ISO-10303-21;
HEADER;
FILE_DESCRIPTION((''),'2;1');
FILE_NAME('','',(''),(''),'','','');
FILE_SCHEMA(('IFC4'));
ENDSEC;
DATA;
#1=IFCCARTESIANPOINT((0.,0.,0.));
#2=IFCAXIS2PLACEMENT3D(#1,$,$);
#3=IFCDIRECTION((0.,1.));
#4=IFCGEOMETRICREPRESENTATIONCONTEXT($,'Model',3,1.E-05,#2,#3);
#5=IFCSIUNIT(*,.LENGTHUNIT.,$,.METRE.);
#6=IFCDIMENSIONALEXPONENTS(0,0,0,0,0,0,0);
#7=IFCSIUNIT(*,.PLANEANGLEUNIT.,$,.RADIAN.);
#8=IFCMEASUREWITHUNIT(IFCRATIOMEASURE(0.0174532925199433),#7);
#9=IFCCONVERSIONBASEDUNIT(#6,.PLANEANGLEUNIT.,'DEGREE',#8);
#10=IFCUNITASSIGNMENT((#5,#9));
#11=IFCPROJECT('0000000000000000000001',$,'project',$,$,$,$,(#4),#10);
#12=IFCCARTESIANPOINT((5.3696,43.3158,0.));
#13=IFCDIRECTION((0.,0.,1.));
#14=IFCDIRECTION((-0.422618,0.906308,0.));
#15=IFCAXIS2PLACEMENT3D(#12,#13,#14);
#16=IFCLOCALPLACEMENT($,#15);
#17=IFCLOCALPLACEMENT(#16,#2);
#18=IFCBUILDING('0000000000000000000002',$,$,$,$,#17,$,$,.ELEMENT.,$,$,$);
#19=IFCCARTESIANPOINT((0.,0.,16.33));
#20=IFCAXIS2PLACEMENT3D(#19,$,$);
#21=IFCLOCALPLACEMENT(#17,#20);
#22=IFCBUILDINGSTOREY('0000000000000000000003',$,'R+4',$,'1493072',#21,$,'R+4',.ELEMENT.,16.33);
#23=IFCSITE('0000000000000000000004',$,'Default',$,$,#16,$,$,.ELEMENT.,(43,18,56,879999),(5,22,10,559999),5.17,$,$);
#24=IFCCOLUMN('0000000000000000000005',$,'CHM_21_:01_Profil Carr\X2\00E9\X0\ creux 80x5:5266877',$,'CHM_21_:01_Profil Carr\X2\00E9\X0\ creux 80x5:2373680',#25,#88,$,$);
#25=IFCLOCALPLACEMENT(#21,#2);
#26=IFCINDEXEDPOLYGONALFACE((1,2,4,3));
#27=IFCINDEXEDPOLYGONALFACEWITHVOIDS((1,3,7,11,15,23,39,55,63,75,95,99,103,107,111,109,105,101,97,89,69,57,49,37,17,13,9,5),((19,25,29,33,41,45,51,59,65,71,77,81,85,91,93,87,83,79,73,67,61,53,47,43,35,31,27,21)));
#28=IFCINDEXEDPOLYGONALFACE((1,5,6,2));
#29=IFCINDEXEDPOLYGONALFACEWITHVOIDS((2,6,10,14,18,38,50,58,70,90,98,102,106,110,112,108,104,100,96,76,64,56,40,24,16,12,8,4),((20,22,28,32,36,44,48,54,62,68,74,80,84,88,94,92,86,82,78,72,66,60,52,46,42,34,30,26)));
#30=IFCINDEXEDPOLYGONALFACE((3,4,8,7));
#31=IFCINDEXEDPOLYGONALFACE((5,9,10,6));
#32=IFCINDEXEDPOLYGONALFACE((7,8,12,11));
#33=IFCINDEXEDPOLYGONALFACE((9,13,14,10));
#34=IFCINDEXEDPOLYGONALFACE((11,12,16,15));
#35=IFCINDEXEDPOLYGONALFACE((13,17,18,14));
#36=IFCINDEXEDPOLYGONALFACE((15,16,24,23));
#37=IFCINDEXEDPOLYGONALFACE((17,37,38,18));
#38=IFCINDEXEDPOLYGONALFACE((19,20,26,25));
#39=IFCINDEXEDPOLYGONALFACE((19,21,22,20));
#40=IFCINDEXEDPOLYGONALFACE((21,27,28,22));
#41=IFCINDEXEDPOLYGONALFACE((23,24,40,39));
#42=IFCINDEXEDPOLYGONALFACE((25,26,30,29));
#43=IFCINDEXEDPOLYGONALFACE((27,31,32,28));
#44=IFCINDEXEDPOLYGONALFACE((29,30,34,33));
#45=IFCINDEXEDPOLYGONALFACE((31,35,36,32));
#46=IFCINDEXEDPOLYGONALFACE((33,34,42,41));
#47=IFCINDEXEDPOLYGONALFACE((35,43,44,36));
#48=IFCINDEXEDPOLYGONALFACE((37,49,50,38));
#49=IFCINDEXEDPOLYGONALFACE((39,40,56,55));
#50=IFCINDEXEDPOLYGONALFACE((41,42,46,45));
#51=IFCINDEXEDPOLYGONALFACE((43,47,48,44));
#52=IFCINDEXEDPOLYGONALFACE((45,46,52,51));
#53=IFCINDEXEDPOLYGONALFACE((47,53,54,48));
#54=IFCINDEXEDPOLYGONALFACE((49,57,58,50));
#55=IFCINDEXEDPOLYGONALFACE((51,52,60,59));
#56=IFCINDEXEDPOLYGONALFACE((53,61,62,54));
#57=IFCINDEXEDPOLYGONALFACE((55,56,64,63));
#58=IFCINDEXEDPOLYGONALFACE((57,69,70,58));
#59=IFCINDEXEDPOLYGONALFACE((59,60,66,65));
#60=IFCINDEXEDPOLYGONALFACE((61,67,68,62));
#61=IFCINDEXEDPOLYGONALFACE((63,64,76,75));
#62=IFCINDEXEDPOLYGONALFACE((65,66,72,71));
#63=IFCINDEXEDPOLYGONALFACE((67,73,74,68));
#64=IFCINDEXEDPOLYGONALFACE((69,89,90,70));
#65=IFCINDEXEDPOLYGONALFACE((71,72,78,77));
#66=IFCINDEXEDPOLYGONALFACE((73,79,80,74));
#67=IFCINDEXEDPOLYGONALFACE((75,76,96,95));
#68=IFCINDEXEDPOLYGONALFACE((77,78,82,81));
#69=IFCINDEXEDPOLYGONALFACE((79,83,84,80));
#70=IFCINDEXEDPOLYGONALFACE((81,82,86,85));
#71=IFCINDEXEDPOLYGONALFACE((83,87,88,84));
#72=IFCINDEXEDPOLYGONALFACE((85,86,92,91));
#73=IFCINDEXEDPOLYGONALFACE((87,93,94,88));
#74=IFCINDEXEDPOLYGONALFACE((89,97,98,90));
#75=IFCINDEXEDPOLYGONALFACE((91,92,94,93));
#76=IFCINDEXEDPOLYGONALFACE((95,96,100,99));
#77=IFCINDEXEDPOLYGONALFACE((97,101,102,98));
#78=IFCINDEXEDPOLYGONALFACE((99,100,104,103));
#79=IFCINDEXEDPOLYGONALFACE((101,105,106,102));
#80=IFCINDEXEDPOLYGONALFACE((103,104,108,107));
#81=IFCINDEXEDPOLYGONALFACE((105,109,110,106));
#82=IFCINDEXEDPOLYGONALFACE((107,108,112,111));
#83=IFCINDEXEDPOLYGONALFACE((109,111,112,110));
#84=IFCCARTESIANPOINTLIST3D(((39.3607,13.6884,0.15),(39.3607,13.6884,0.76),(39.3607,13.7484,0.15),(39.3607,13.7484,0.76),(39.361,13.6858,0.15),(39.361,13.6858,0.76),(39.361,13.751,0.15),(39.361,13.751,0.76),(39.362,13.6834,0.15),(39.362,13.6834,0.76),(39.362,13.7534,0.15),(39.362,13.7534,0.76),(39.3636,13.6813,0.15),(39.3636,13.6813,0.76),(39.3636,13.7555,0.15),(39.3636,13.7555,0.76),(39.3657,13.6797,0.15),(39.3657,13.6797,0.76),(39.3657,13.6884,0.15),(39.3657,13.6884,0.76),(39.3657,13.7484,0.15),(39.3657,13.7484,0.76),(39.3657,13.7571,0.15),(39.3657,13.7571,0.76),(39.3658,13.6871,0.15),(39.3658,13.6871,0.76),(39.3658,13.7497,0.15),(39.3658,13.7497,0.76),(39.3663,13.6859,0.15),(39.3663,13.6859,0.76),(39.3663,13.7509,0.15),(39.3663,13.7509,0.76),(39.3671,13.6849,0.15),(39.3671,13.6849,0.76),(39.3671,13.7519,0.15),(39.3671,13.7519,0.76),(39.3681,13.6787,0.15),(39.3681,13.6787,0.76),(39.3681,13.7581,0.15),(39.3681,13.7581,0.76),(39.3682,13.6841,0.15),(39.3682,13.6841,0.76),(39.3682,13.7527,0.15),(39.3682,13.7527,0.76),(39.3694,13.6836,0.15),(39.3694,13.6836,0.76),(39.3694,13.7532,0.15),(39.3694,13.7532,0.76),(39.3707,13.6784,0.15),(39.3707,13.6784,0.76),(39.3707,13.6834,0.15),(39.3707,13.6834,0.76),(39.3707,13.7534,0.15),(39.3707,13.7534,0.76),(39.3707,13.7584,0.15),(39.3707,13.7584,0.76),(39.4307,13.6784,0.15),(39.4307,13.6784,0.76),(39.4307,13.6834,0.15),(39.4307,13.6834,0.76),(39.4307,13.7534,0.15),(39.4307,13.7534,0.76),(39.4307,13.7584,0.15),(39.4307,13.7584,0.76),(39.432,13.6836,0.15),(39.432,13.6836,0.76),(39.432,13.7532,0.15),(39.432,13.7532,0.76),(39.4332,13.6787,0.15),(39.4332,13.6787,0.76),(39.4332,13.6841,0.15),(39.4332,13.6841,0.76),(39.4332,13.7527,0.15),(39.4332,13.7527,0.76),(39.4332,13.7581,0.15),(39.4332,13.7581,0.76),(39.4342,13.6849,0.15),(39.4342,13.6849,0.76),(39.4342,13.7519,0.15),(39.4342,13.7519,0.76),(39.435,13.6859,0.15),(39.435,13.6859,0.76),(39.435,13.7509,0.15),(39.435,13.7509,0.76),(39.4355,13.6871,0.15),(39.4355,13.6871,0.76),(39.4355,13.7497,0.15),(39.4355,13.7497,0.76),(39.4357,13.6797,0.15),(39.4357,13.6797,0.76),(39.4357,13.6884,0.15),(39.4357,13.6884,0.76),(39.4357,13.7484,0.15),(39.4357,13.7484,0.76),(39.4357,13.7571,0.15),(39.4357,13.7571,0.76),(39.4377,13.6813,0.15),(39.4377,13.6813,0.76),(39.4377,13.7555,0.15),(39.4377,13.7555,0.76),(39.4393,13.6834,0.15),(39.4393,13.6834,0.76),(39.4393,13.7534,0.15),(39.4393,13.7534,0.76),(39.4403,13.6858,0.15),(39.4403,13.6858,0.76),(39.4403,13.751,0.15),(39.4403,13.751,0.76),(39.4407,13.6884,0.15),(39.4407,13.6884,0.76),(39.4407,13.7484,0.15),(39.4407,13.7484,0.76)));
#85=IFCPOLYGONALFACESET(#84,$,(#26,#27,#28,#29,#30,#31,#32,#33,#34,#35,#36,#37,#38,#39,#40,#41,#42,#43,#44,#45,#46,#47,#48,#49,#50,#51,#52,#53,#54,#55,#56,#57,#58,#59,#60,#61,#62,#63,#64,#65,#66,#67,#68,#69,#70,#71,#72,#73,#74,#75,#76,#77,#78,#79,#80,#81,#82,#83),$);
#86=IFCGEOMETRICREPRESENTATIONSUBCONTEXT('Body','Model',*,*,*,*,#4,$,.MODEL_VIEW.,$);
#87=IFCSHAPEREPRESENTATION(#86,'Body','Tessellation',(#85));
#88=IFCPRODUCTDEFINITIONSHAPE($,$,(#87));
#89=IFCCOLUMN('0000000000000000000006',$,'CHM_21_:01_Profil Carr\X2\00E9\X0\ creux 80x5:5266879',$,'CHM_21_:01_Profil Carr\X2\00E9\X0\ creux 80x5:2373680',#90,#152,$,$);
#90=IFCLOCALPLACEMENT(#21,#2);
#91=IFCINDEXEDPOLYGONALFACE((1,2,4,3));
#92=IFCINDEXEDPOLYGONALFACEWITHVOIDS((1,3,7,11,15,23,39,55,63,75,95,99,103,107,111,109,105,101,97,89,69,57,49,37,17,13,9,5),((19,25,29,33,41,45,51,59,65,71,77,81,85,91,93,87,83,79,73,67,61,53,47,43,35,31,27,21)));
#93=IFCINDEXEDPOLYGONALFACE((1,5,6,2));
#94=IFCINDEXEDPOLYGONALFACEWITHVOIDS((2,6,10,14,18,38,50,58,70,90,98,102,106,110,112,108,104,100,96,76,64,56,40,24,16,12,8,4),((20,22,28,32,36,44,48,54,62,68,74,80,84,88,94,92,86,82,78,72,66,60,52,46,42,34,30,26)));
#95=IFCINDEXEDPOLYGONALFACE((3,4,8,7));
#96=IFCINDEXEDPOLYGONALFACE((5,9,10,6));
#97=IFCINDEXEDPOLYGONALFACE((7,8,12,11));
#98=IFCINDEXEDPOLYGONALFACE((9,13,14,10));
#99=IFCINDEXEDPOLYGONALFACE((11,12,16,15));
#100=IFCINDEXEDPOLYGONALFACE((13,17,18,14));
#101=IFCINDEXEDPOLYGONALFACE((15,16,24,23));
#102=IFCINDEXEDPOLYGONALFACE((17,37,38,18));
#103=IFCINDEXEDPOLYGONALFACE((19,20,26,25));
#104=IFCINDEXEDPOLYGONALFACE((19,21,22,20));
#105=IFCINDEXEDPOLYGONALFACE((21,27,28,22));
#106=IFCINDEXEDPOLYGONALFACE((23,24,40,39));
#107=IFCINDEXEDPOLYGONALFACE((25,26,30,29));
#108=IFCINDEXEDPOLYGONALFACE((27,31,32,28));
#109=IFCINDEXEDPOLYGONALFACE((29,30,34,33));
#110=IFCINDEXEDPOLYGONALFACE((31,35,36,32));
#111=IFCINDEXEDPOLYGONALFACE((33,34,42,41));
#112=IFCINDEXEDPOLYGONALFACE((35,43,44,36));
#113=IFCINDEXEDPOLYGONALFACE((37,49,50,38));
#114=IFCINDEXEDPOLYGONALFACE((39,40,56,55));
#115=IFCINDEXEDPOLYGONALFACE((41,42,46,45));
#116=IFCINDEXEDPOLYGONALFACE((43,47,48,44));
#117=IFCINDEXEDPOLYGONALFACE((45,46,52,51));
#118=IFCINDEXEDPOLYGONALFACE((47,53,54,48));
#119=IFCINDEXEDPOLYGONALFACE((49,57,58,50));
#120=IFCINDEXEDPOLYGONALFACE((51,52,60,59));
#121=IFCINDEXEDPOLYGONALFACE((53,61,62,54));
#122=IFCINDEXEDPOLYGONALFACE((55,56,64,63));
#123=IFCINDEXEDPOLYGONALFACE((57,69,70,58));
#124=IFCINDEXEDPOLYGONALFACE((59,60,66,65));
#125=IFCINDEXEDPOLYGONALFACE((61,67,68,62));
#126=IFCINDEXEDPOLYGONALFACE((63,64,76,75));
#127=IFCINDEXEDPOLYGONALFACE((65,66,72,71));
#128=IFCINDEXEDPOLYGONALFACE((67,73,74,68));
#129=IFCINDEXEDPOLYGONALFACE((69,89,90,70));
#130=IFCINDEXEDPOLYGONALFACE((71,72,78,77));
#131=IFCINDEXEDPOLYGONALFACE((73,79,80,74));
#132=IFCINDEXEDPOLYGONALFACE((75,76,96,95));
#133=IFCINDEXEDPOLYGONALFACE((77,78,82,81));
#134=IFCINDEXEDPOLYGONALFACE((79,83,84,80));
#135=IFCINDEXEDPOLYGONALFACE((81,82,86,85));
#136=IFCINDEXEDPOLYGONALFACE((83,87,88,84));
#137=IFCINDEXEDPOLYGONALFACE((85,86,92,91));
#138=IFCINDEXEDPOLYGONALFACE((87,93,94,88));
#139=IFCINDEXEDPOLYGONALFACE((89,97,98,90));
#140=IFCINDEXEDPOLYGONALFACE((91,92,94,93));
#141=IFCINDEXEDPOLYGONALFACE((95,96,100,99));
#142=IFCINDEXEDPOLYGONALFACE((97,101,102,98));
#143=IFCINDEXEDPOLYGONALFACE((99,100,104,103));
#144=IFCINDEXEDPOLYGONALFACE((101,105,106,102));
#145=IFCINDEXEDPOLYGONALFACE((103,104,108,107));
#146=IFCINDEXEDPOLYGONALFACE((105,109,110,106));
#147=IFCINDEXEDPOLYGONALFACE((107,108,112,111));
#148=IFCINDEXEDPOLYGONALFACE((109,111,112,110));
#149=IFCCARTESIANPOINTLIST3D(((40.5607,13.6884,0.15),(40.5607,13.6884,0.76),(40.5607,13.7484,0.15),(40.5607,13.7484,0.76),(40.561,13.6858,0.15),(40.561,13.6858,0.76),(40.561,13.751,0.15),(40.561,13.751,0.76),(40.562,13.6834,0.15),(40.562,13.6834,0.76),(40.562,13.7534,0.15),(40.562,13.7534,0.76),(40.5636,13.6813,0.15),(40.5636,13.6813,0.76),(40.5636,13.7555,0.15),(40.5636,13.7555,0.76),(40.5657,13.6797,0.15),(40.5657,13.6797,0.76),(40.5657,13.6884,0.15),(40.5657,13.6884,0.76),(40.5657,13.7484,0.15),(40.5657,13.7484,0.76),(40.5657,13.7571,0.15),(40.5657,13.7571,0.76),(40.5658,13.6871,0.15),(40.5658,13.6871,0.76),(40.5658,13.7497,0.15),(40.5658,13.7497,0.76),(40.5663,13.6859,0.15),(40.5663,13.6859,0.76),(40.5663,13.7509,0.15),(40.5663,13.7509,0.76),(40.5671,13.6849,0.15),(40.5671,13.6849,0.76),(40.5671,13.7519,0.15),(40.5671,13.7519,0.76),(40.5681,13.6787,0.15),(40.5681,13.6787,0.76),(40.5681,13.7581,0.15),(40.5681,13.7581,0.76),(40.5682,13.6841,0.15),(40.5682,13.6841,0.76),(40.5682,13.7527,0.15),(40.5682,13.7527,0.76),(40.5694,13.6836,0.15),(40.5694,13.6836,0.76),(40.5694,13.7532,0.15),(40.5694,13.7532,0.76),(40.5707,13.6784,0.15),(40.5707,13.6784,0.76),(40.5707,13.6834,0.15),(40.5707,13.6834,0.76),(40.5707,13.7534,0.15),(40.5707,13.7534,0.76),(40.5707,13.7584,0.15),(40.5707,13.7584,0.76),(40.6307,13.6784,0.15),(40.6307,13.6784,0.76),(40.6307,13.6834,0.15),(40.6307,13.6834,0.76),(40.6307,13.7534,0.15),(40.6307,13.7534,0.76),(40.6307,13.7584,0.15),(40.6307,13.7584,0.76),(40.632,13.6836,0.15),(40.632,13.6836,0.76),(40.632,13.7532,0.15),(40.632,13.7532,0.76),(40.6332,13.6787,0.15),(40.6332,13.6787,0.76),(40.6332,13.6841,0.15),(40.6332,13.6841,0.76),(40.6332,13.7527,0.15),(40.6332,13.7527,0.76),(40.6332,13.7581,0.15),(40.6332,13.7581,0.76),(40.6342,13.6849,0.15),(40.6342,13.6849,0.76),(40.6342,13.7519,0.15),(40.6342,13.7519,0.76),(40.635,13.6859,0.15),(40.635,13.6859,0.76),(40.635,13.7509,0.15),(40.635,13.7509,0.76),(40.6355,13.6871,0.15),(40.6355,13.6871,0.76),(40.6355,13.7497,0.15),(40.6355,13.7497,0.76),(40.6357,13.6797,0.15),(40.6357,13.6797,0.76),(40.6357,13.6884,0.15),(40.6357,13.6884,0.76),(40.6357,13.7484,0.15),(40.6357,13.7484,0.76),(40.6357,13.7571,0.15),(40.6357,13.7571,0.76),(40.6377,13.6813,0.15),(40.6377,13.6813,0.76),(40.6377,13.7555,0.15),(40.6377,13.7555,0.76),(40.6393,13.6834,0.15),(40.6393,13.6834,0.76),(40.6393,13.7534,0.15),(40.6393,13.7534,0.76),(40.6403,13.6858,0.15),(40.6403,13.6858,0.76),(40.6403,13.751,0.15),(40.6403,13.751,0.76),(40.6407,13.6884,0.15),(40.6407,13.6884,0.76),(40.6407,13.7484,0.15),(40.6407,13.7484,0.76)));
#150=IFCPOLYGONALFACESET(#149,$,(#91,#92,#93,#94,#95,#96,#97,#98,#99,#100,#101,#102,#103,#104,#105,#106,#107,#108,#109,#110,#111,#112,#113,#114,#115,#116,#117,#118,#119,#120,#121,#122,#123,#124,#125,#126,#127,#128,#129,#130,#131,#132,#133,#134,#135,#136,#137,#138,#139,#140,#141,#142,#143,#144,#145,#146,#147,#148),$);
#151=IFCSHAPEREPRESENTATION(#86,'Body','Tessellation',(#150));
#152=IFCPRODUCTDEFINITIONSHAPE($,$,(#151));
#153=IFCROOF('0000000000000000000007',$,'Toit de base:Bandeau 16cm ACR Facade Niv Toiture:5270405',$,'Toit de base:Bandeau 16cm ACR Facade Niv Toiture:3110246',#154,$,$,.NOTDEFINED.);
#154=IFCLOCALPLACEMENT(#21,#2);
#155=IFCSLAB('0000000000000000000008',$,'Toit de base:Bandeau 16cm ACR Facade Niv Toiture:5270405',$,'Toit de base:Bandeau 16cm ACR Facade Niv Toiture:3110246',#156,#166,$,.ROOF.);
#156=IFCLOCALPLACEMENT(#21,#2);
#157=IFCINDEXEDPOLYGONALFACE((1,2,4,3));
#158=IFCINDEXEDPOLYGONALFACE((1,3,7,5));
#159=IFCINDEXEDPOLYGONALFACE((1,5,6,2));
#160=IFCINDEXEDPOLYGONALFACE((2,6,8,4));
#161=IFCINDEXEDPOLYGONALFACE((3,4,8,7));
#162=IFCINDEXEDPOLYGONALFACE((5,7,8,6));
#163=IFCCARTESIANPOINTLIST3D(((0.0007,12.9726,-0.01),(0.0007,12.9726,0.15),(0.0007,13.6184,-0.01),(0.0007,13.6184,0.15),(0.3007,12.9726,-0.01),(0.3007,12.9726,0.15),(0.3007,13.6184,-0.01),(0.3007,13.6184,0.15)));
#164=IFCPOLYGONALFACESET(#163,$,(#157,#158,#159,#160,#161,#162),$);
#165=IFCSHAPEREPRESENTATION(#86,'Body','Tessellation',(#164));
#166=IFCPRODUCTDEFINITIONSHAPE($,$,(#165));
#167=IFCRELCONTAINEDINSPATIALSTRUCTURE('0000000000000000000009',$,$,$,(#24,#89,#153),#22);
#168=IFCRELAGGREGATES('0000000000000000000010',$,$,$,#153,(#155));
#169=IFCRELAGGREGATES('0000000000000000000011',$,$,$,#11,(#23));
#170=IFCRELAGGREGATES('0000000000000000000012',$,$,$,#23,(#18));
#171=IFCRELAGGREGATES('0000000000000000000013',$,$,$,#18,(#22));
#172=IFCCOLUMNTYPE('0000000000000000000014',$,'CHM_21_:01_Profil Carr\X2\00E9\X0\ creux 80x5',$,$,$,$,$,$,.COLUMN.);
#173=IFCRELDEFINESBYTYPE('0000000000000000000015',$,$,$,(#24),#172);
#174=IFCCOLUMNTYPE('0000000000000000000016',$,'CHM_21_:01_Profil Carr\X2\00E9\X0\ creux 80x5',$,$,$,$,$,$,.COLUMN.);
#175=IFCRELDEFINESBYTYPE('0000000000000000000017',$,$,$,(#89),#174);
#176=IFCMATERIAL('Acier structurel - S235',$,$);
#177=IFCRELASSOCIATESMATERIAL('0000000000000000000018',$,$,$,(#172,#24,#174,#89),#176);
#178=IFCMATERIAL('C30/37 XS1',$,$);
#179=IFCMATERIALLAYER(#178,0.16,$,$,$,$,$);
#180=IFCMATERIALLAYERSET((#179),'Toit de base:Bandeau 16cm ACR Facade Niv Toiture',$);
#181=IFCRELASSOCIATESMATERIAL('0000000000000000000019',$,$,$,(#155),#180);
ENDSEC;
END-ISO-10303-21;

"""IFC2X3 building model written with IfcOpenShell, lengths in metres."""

from ifc_helpers import new_model, entity, si_unit, converted_unit, direction, frame, frame_2d, origin, place, context, subcontext, project, spatial, polyline, circle_curve, parameter, trimmed, segment, composite_curve, rectangle, outline, extrude, source, transform, mapped, material, layer, layer_set, type_object, type_shapes, element, aggregate, save


model = new_model("IFC2X3")

# Units and contexts
model_context = context("Model", 3, precision=1e-05, world=origin(), true_north=direction((0.0, 1.0)))
body_context = subcontext(model_context, "Body", "Model", "MODEL_VIEW")
ifc_project = project(units=[si_unit("LENGTHUNIT", "METRE"), converted_unit("PLANEANGLEUNIT", "DEGREE", entity("IfcRatioMeasure", 0.0174532925199433), si_unit("PLANEANGLEUNIT", "RADIAN"), dimensions=[0, 0, 0, 0, 0, 0, 0])], contexts=[model_context])

# Site, building, storey
site_placement = place(None, frame((5.3696, 43.3158, 0.0), z_axis=(0.0, 0.0, 1.0), x_axis=(-0.422618, 0.906308, 0.0)))
site = spatial("IfcSite", under=ifc_project, at=site_placement, Name="Default", CompositionType="ELEMENT", RefLatitude=(43, 18, 56, 879999), RefLongitude=(5, 22, 10, 559999), RefElevation=5.17)
building_placement = place(site_placement, origin())
building = spatial("IfcBuilding", under=site, at=building_placement, CompositionType="ELEMENT")
storey_placement = place(building_placement, frame((0.0, 0.0, 16.33)))
storey = spatial("IfcBuildingStorey", under=building, at=storey_placement, Name="R+4", ObjectType="1493072", LongName="R+4", CompositionType="ELEMENT", Elevation=16.33)

# Columns
ifc_material_1 = material(Name="Acier structurel - S235")
column_type_1 = type_object("IfcColumnType", Name="CHM_21_:01_Profil Carré creux 80x5", PredefinedType="COLUMN", material=ifc_material_1)
shared_shape_1 = source(origin(), body_context, "Body", "SweptSolid", [
    extrude(outline(composite_curve([segment(polyline([(-0.03, -0.04), (0.03, -0.04)]), True, "CONTINUOUS"), segment(trimmed(circle_curve(frame_2d((0.03, -0.03), x_axis=(-1.0, 0.0)), 0.01), [parameter(90.0)], [parameter(180.0)], True, "PARAMETER"), True, "CONTINUOUS"), segment(polyline([(0.04, -0.03), (0.04, 0.03)]), True, "CONTINUOUS"), segment(trimmed(circle_curve(frame_2d((0.03, 0.03), x_axis=(-1.0, 0.0)), 0.01), [parameter(180.0)], [parameter(270.0)], True, "PARAMETER"), True, "CONTINUOUS"), segment(polyline([(0.03, 0.04), (-0.03, 0.04)]), True, "CONTINUOUS"), segment(trimmed(circle_curve(frame_2d((-0.03, 0.03), x_axis=(-1.0, 0.0)), 0.01), [parameter(270.0)], [parameter(360.0)], True, "PARAMETER"), True, "CONTINUOUS"), segment(polyline([(-0.04, 0.03), (-0.04, -0.03)]), True, "CONTINUOUS"), segment(trimmed(circle_curve(frame_2d((-0.03, -0.03), x_axis=(-1.0, 0.0)), 0.01), [parameter(360.0)], [parameter(90.0)], True, "PARAMETER"), True, "CONTINUOUS")], self_intersect=False), holes=[composite_curve([segment(trimmed(circle_curve(frame_2d((-0.03, -0.03), x_axis=(-1.0, 0.0)), 0.005), [parameter(360.0)], [parameter(90.0)], True, "PARAMETER"), False, "CONTINUOUS"), segment(polyline([(-0.035, -0.03), (-0.035, 0.03)]), True, "CONTINUOUS"), segment(trimmed(circle_curve(frame_2d((-0.03, 0.03), x_axis=(-1.0, 0.0)), 0.005), [parameter(270.0)], [parameter(360.0)], True, "PARAMETER"), False, "CONTINUOUS"), segment(polyline([(-0.03, 0.035), (0.03, 0.035)]), True, "CONTINUOUS"), segment(trimmed(circle_curve(frame_2d((0.03, 0.03), x_axis=(-1.0, 0.0)), 0.005), [parameter(180.0)], [parameter(270.0)], True, "PARAMETER"), False, "CONTINUOUS"), segment(polyline([(0.035, 0.03), (0.035, -0.03)]), True, "CONTINUOUS"), segment(trimmed(circle_curve(frame_2d((0.03, -0.03), x_axis=(-1.0, 0.0)), 0.005), [parameter(90.0)], [parameter(180.0)], True, "PARAMETER"), False, "CONTINUOUS"), segment(polyline([(0.03, -0.035), (-0.03, -0.035)]), True, "CONTINUOUS")], self_intersect=False)]), frame((39.4007, 13.7184, 16.48), z_axis=(0.0, 0.0, 1.0), x_axis=(0.0, 1.0, 0.0)), (0.0, 0.0, 1.0), 0.61),
])
type_shapes(column_type_1, [shared_shape_1])
column_1_placement = place(storey_placement, frame((0.0, 0.0, -16.33)))
element("IfcColumn", 1, at=column_1_placement, inside=storey, type_object=column_type_1, material=ifc_material_1, Name="CHM_21_:01_Profil Carré creux 80x5:5266877", ObjectType="CHM_21_:01_Profil Carré creux 80x5:2373680", context=body_context, shape_type="MappedRepresentation", body=[
    mapped(shared_shape_1, transform((0.0, 0.0, 0.0), scale=1.0)),
])
column_type_2 = type_object("IfcColumnType", Name="CHM_21_:01_Profil Carré creux 80x5", PredefinedType="COLUMN", material=ifc_material_1)
shared_shape_2 = source(origin(), body_context, "Body", "SweptSolid", [
    extrude(outline(composite_curve([segment(polyline([(-0.03, -0.04), (0.03, -0.04)]), True, "CONTINUOUS"), segment(trimmed(circle_curve(frame_2d((0.03, -0.03), x_axis=(-1.0, 0.0)), 0.01), [parameter(90.0)], [parameter(180.0)], True, "PARAMETER"), True, "CONTINUOUS"), segment(polyline([(0.04, -0.03), (0.04, 0.03)]), True, "CONTINUOUS"), segment(trimmed(circle_curve(frame_2d((0.03, 0.03), x_axis=(-1.0, 0.0)), 0.01), [parameter(180.0)], [parameter(270.0)], True, "PARAMETER"), True, "CONTINUOUS"), segment(polyline([(0.03, 0.04), (-0.03, 0.04)]), True, "CONTINUOUS"), segment(trimmed(circle_curve(frame_2d((-0.03, 0.03), x_axis=(-1.0, 0.0)), 0.01), [parameter(270.0)], [parameter(360.0)], True, "PARAMETER"), True, "CONTINUOUS"), segment(polyline([(-0.04, 0.03), (-0.04, -0.03)]), True, "CONTINUOUS"), segment(trimmed(circle_curve(frame_2d((-0.03, -0.03), x_axis=(-1.0, 0.0)), 0.01), [parameter(360.0)], [parameter(90.0)], True, "PARAMETER"), True, "CONTINUOUS")], self_intersect=False), holes=[composite_curve([segment(trimmed(circle_curve(frame_2d((-0.03, -0.03), x_axis=(-1.0, 0.0)), 0.005), [parameter(360.0)], [parameter(90.0)], True, "PARAMETER"), False, "CONTINUOUS"), segment(polyline([(-0.035, -0.03), (-0.035, 0.03)]), True, "CONTINUOUS"), segment(trimmed(circle_curve(frame_2d((-0.03, 0.03), x_axis=(-1.0, 0.0)), 0.005), [parameter(270.0)], [parameter(360.0)], True, "PARAMETER"), False, "CONTINUOUS"), segment(polyline([(-0.03, 0.035), (0.03, 0.035)]), True, "CONTINUOUS"), segment(trimmed(circle_curve(frame_2d((0.03, 0.03), x_axis=(-1.0, 0.0)), 0.005), [parameter(180.0)], [parameter(270.0)], True, "PARAMETER"), False, "CONTINUOUS"), segment(polyline([(0.035, 0.03), (0.035, -0.03)]), True, "CONTINUOUS"), segment(trimmed(circle_curve(frame_2d((0.03, -0.03), x_axis=(-1.0, 0.0)), 0.005), [parameter(90.0)], [parameter(180.0)], True, "PARAMETER"), False, "CONTINUOUS"), segment(polyline([(0.03, -0.035), (-0.03, -0.035)]), True, "CONTINUOUS")], self_intersect=False)]), frame((40.6007, 13.7184, 16.48), z_axis=(0.0, 0.0, 1.0), x_axis=(0.0, 1.0, 0.0)), (0.0, 0.0, 1.0), 0.61),
])
type_shapes(column_type_2, [shared_shape_2])
column_2_placement = place(storey_placement, frame((0.0, 0.0, -16.33)))
element("IfcColumn", 2, at=column_2_placement, inside=storey, type_object=column_type_2, material=ifc_material_1, Name="CHM_21_:01_Profil Carré creux 80x5:5266879", ObjectType="CHM_21_:01_Profil Carré creux 80x5:2373680", context=body_context, shape_type="MappedRepresentation", body=[
    mapped(shared_shape_2, transform((0.0, 0.0, 0.0), scale=1.0)),
])

# Shared definitions
ifc_material_2 = material(Name="C30/37 XS1")

# Roof, slab
roof_placement = place(storey_placement, frame((0.0007, 12.9726, -0.01)))
roof = element("IfcRoof", 3, at=roof_placement, inside=storey, Name="Toit de base:Bandeau 16cm ACR Facade Niv Toiture:5270405", ObjectType="Toit de base:Bandeau 16cm ACR Facade Niv Toiture:3110246", ShapeType="NOTDEFINED")
ifc_layer_1 = layer(ifc_material_2, 0.16)
ifc_layer_set_1 = layer_set([ifc_layer_1], Name="Toit de base:Bandeau 16cm ACR Facade Niv Toiture")
slab_placement = place(roof_placement, origin())
slab = element("IfcSlab", 4, at=slab_placement, material=ifc_layer_set_1, Name="Toit de base:Bandeau 16cm ACR Facade Niv Toiture:5270405", ObjectType="Toit de base:Bandeau 16cm ACR Facade Niv Toiture:3110246", PredefinedType="ROOF", context=body_context, shape_type="SweptSolid", body=[
    extrude(rectangle(XDim=0.3, YDim=0.6458, at=frame_2d((0.0, 0.0), x_axis=(-1.0, 0.0))), frame((0.15, 0.3229, 0.0)), (0.0, 0.0, 1.0), 0.16),
])
aggregate(roof, [slab])

save(model, "model.ifc")
